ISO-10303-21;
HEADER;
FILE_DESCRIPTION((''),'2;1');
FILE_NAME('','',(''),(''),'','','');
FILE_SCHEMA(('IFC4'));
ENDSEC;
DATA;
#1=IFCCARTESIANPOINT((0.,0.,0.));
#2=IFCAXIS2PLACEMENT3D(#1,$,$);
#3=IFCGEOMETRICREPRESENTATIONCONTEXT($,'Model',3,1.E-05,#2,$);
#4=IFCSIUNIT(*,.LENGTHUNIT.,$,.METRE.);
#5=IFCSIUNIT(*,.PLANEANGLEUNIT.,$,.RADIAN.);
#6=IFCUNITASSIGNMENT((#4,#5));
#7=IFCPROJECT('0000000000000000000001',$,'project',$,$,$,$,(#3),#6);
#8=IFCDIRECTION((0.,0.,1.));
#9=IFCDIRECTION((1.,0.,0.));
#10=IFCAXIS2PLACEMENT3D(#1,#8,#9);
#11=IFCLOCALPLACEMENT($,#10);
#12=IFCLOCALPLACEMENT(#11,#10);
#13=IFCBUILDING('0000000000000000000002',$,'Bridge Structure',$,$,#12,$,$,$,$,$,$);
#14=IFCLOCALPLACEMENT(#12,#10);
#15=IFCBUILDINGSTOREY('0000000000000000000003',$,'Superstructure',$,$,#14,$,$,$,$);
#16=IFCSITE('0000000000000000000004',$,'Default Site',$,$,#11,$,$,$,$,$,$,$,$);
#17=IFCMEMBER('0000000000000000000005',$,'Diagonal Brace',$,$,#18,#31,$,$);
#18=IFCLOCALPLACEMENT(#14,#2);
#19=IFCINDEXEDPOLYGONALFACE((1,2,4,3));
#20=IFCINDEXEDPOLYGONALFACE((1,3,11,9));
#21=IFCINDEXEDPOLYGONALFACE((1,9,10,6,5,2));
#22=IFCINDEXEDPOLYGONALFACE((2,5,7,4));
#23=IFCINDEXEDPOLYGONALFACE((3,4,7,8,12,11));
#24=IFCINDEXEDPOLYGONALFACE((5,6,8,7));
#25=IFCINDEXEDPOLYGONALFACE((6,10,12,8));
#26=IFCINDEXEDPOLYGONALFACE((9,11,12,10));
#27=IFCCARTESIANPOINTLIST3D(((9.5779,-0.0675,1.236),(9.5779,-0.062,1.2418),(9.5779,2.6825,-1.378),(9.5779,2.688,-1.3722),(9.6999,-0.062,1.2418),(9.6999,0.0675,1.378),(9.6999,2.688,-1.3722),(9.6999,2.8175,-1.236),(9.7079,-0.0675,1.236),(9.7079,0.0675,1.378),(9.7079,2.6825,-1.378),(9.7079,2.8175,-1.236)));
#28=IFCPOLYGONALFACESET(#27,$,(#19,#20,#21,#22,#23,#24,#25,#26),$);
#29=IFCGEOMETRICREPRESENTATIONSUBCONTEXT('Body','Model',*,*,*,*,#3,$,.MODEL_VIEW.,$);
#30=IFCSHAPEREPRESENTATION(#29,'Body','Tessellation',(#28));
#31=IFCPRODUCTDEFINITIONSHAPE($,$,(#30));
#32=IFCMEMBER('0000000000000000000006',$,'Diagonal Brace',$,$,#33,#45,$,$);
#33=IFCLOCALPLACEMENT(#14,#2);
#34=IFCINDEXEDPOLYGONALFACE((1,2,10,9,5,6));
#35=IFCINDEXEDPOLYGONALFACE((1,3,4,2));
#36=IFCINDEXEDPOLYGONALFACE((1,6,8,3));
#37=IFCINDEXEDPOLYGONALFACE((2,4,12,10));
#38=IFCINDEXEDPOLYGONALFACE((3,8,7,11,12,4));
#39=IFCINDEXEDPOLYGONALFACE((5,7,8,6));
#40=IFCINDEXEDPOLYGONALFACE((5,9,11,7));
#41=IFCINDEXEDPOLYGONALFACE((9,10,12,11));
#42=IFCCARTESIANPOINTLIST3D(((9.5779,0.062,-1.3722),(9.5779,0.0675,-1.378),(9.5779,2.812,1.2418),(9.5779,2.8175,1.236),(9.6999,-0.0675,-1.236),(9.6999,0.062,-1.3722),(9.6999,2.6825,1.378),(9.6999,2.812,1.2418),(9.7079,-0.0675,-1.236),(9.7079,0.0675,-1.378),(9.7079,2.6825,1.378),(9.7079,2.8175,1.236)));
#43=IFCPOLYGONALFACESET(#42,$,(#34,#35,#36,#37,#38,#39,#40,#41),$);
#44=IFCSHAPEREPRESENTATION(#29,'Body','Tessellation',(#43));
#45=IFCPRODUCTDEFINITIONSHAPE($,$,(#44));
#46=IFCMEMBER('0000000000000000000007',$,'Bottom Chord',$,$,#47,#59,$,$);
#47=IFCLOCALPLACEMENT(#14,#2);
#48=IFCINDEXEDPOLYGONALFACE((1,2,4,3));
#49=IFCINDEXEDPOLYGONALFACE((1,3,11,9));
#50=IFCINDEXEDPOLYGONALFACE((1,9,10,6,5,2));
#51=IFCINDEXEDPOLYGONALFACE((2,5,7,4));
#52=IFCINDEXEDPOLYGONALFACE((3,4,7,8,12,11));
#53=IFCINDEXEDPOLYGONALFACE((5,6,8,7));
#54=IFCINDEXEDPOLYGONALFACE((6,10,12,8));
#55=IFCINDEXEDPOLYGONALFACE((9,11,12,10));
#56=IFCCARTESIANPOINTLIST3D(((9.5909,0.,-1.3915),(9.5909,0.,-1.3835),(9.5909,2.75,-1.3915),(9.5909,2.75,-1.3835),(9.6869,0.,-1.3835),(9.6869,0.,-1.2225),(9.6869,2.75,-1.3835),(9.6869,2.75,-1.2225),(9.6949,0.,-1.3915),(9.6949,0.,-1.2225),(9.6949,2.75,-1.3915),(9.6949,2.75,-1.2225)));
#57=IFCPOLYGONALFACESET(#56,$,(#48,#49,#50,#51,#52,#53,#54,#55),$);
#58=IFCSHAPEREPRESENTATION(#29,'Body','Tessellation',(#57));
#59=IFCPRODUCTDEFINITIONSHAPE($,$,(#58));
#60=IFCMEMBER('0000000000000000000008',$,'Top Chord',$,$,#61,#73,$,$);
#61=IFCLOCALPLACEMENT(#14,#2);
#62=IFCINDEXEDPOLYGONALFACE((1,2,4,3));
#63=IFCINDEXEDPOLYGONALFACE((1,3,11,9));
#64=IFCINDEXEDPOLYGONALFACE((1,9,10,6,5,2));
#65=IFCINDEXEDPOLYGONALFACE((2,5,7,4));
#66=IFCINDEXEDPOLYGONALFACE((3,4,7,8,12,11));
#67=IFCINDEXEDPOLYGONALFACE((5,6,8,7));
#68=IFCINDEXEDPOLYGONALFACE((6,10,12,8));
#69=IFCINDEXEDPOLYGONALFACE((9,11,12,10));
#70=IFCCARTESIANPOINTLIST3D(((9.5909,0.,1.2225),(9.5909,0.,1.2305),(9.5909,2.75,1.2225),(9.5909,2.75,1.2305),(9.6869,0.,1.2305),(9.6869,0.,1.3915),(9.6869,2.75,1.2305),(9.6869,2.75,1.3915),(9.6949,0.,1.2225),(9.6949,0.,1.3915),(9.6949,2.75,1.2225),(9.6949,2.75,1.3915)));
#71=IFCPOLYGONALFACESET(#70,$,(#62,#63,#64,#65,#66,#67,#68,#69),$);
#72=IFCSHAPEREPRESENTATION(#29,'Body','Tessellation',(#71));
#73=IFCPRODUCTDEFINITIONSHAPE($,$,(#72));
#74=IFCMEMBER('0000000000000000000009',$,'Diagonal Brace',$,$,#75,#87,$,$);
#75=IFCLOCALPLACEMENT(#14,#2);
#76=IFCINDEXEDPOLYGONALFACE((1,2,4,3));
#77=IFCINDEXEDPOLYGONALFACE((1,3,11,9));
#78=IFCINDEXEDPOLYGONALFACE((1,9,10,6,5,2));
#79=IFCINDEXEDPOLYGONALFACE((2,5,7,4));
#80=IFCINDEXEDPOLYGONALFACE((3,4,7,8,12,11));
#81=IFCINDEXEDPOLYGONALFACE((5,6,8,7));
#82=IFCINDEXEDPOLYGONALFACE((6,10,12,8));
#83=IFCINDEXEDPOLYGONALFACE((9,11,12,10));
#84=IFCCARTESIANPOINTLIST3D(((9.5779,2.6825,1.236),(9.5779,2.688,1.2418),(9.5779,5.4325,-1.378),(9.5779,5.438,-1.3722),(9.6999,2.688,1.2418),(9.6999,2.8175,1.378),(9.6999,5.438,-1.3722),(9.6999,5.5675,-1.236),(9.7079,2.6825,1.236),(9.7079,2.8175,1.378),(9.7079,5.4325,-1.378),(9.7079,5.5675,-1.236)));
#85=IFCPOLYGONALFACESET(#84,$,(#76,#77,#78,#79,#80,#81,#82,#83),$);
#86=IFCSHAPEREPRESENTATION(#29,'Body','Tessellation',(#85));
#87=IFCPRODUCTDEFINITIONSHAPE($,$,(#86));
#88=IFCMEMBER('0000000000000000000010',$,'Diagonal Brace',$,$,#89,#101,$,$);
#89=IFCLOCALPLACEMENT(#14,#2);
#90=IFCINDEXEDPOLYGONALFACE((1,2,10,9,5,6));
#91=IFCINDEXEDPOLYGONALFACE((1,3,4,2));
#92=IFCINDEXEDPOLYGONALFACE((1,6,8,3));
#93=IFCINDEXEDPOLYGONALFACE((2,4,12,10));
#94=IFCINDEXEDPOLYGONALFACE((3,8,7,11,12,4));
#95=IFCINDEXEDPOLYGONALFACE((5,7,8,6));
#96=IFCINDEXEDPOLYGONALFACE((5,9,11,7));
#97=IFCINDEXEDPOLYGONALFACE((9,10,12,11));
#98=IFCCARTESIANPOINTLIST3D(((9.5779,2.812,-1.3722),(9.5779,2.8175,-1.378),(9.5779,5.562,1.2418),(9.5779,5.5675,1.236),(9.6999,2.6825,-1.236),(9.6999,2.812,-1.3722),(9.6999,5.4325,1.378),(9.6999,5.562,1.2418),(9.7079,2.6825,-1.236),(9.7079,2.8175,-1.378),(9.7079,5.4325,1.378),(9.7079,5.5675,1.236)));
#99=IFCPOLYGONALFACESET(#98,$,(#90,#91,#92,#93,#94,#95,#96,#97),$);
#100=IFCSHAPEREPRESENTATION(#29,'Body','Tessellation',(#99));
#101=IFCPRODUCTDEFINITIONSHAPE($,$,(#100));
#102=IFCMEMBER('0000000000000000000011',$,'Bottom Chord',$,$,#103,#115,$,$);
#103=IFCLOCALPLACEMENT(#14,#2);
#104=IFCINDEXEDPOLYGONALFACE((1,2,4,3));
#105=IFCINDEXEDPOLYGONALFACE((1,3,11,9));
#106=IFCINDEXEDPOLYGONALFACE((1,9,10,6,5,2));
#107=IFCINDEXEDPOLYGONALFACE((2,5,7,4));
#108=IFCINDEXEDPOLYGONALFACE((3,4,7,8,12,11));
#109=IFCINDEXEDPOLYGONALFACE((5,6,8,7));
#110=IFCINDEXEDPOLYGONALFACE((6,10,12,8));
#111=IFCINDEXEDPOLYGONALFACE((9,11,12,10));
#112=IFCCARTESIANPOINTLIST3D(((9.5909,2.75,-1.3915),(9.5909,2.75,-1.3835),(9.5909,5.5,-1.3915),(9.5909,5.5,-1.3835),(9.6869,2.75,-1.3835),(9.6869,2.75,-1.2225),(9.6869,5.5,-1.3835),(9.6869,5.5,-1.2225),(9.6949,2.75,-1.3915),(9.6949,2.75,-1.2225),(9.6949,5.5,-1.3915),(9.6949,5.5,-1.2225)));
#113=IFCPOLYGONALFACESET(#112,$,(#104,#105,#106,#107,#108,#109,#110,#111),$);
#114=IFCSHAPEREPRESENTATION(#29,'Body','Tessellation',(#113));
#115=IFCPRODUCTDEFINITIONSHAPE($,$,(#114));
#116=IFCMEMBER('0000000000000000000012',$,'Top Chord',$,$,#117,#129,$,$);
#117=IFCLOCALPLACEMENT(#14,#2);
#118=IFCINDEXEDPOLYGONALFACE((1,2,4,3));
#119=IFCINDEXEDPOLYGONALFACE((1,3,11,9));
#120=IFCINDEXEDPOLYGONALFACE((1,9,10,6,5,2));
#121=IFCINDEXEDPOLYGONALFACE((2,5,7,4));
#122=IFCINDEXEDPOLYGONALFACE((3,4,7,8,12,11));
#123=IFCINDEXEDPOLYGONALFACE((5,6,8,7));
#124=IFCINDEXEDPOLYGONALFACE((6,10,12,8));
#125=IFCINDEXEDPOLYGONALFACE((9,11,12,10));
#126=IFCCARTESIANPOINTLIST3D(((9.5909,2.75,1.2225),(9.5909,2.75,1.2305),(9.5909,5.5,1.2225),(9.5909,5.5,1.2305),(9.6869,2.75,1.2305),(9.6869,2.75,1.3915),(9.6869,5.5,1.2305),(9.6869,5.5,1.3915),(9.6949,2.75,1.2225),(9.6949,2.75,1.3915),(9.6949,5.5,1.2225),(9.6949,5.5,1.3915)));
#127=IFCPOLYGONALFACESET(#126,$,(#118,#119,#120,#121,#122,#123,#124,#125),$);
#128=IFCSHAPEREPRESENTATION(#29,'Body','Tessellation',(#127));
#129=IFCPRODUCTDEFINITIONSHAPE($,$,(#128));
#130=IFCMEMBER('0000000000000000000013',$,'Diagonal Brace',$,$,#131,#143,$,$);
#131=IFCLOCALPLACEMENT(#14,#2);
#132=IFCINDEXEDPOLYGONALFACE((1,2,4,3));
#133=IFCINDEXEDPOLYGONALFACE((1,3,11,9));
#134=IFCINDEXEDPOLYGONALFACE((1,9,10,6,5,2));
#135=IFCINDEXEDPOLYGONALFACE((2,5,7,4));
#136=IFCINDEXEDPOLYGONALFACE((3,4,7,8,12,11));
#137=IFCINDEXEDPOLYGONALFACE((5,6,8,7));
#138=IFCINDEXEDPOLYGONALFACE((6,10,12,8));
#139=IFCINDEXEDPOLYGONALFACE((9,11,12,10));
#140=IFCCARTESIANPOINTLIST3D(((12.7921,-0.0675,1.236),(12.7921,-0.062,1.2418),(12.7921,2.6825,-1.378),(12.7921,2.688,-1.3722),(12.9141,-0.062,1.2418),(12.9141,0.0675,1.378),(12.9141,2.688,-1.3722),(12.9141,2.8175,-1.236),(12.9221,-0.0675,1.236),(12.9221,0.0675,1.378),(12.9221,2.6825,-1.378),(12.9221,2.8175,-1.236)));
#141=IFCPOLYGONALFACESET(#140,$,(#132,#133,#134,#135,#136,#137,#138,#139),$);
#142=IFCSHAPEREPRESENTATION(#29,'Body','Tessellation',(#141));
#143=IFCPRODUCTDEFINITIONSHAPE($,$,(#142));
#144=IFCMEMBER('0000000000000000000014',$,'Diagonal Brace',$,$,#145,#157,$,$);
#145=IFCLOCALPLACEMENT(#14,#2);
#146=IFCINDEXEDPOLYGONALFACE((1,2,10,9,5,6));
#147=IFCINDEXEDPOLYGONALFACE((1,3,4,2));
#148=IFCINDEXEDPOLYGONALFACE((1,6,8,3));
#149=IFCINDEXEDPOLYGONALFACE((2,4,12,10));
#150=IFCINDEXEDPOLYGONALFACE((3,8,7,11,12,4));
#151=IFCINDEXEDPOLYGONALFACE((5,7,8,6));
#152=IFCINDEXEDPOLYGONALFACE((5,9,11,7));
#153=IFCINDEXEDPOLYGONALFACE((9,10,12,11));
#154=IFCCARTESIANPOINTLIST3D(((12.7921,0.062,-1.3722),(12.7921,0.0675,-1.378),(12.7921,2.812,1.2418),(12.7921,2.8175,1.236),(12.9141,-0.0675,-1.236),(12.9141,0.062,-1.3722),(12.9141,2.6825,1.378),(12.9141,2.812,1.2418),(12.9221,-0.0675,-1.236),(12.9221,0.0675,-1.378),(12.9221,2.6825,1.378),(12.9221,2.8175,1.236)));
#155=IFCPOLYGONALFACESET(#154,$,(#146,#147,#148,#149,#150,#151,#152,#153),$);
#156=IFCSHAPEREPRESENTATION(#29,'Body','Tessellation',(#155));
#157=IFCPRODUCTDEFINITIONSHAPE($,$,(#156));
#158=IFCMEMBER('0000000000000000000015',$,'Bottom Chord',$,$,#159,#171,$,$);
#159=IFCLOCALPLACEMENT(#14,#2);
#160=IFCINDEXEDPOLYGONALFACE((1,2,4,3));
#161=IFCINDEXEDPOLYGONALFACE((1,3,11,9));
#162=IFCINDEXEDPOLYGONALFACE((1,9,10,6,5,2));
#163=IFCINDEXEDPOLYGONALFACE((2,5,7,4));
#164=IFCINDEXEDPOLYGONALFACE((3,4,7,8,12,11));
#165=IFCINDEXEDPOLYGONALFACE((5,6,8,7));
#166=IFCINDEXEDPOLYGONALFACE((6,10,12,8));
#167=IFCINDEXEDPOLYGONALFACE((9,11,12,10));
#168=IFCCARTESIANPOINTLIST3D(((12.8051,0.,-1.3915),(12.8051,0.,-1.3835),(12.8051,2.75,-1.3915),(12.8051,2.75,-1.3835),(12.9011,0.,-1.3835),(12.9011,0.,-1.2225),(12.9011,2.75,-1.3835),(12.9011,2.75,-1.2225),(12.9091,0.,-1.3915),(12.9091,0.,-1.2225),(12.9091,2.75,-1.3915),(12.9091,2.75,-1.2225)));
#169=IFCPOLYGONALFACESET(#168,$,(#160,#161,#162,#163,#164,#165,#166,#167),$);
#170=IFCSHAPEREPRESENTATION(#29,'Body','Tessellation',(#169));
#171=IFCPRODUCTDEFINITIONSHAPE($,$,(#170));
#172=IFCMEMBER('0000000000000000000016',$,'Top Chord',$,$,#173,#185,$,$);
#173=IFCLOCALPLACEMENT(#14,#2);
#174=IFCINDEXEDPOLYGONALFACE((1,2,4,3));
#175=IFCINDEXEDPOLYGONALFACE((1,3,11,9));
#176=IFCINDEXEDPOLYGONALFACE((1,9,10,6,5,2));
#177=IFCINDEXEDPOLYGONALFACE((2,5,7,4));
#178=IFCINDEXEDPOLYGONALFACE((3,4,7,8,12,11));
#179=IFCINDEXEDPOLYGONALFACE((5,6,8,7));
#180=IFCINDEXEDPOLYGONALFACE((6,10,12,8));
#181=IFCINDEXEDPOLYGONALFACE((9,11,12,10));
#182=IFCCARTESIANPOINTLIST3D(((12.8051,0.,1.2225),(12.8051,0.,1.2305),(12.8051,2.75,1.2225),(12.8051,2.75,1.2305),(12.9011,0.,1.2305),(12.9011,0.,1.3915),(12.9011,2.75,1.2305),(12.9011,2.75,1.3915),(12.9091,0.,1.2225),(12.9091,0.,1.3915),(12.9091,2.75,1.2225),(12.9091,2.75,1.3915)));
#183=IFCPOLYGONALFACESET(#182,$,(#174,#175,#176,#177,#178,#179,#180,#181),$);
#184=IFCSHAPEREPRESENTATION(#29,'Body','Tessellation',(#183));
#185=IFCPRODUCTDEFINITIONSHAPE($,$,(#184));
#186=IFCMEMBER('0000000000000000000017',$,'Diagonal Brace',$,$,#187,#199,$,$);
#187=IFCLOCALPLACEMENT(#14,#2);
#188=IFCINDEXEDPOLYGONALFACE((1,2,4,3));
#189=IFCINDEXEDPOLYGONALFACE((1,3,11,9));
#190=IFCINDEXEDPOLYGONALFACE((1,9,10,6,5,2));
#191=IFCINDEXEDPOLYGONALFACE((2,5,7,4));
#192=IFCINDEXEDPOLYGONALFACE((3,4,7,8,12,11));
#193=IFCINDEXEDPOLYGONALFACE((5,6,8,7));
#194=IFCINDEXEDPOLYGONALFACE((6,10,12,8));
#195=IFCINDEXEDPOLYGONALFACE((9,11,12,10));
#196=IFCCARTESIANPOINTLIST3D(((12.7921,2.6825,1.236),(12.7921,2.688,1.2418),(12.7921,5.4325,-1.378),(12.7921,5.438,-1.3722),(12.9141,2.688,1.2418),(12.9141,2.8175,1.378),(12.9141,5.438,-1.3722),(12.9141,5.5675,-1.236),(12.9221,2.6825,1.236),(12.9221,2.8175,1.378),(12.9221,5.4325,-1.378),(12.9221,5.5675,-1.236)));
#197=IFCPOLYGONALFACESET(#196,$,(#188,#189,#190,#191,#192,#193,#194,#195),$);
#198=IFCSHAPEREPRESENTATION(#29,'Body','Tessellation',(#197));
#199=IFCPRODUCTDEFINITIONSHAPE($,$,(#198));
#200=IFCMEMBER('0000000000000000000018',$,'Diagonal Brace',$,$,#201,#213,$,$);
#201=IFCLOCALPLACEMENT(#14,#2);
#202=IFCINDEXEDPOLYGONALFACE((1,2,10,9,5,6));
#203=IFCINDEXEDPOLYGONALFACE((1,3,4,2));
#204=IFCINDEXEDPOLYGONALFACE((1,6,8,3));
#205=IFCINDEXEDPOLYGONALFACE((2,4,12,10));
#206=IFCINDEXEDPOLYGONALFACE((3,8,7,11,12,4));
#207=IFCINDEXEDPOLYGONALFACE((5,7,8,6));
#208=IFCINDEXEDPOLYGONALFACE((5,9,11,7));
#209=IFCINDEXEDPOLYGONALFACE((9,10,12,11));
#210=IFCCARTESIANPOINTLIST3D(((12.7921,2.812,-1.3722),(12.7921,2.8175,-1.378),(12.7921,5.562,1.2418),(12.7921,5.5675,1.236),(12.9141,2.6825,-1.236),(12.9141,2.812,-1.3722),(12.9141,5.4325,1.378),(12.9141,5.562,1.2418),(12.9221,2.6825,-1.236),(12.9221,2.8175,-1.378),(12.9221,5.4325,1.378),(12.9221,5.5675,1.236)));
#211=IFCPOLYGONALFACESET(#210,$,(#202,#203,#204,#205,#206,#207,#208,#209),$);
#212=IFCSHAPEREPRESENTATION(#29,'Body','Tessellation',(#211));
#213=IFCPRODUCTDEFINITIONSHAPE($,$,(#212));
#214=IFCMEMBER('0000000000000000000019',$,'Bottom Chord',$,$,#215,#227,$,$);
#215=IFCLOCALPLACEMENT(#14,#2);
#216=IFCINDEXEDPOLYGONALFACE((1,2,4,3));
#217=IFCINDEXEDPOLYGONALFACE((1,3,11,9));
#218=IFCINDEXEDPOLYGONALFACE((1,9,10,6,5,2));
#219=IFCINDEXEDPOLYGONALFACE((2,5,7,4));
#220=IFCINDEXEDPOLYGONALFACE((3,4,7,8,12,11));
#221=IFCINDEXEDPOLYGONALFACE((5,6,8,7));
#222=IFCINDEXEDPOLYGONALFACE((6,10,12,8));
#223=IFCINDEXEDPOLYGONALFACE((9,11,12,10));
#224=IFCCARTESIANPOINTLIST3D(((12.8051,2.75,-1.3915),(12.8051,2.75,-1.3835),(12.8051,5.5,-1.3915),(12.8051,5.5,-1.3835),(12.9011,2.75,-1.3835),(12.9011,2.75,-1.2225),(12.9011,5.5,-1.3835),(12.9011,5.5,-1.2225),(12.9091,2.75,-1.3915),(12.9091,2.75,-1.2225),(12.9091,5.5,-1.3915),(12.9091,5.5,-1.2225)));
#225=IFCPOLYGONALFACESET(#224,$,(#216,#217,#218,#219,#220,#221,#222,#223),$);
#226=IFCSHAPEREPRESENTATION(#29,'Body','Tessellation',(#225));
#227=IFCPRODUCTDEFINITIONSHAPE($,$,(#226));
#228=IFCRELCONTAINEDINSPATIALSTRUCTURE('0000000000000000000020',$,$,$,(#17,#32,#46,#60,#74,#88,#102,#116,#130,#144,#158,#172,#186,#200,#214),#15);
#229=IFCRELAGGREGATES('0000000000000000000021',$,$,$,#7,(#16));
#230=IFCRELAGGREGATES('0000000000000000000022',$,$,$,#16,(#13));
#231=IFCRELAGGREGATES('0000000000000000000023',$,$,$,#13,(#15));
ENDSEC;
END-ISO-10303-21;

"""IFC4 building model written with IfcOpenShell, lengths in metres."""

from ifc_helpers import new_model, si_unit, frame, origin, origin_with_axes, origin_2d_with_axis, place, context, subcontext, project, spatial, l_section, extrude, element, save


model = new_model("IFC4")

# Units and contexts
model_context = context("Model", 3, precision=1e-05, world=origin())
body_context = subcontext(model_context, "Body", "Model", "MODEL_VIEW")
ifc_project = project(units=[si_unit("LENGTHUNIT", "METRE"), si_unit("PLANEANGLEUNIT", "RADIAN")], contexts=[model_context])

# Site, building, storey
site_placement = place(None, origin_with_axes())
site = spatial("IfcSite", under=ifc_project, at=site_placement, Name="Default Site")
building_placement = place(site_placement, origin_with_axes())
building = spatial("IfcBuilding", under=site, at=building_placement, Name="Bridge Structure")
storey_placement = place(building_placement, origin_with_axes())
storey = spatial("IfcBuildingStorey", under=building, at=storey_placement, Name="Superstructure")

# Members
for number, where, z_axis, x_axis, name in (
    (1, (9.6429, 0.0, 1.307), (0.0, 0.724802, -0.688957), (-1.0, 0.0, 0.0), "Diagonal Brace"),
    (2, (9.6429, 0.0, -1.307), (0.0, 0.724802, 0.688957), (-1.0, 0.0, 0.0), "Diagonal Brace"),
):
    element("IfcMember", number, at=place(storey_placement, frame(where, z_axis=z_axis, x_axis=x_axis)), inside=storey, Name=name, context=body_context, shape_type="SweptSolid", body=[
        extrude(l_section(Depth=0.196, Width=0.13, Thickness=0.008, at=origin_2d_with_axis()), origin_with_axes(), (0.0, 0.0, 1.0), 3.7941),
    ])
for number, where, z_axis, x_axis, name in (
    (3, (9.6429, 0.0, -1.307), (0.0, 1.0, 0.0), (-1.0, 0.0, 0.0), "Bottom Chord"),
    (4, (9.6429, 0.0, 1.307), (0.0, 1.0, 0.0), (-1.0, 0.0, 0.0), "Top Chord"),
):
    element("IfcMember", number, at=place(storey_placement, frame(where, z_axis=z_axis, x_axis=x_axis)), inside=storey, Name=name, context=body_context, shape_type="SweptSolid", body=[
        extrude(l_section(Depth=0.169, Width=0.104, Thickness=0.008, at=origin_2d_with_axis()), origin_with_axes(), (0.0, 0.0, 1.0), 2.75),
    ])
for number, where, z_axis, x_axis, name in (
    (5, (9.6429, 2.75, 1.307), (0.0, 0.724802, -0.688957), (-1.0, 0.0, 0.0), "Diagonal Brace"),
    (6, (9.6429, 2.75, -1.307), (0.0, 0.724802, 0.688957), (-1.0, 0.0, 0.0), "Diagonal Brace"),
):
    element("IfcMember", number, at=place(storey_placement, frame(where, z_axis=z_axis, x_axis=x_axis)), inside=storey, Name=name, context=body_context, shape_type="SweptSolid", body=[
        extrude(l_section(Depth=0.196, Width=0.13, Thickness=0.008, at=origin_2d_with_axis()), origin_with_axes(), (0.0, 0.0, 1.0), 3.7941),
    ])
for number, where, z_axis, x_axis, name in (
    (7, (9.6429, 2.75, -1.307), (0.0, 1.0, 0.0), (-1.0, 0.0, 0.0), "Bottom Chord"),
    (8, (9.6429, 2.75, 1.307), (0.0, 1.0, 0.0), (-1.0, 0.0, 0.0), "Top Chord"),
):
    element("IfcMember", number, at=place(storey_placement, frame(where, z_axis=z_axis, x_axis=x_axis)), inside=storey, Name=name, context=body_context, shape_type="SweptSolid", body=[
        extrude(l_section(Depth=0.169, Width=0.104, Thickness=0.008, at=origin_2d_with_axis()), origin_with_axes(), (0.0, 0.0, 1.0), 2.75),
    ])
for number, where, z_axis, x_axis, name in (
    (9, (12.8571, 0.0, 1.307), (0.0, 0.724802, -0.688957), (-1.0, 0.0, 0.0), "Diagonal Brace"),
    (10, (12.8571, 0.0, -1.307), (0.0, 0.724802, 0.688957), (-1.0, 0.0, 0.0), "Diagonal Brace"),
):
    element("IfcMember", number, at=place(storey_placement, frame(where, z_axis=z_axis, x_axis=x_axis)), inside=storey, Name=name, context=body_context, shape_type="SweptSolid", body=[
        extrude(l_section(Depth=0.196, Width=0.13, Thickness=0.008, at=origin_2d_with_axis()), origin_with_axes(), (0.0, 0.0, 1.0), 3.7941),
    ])
for number, where, z_axis, x_axis, name in (
    (11, (12.8571, 0.0, -1.307), (0.0, 1.0, 0.0), (-1.0, 0.0, 0.0), "Bottom Chord"),
    (12, (12.8571, 0.0, 1.307), (0.0, 1.0, 0.0), (-1.0, 0.0, 0.0), "Top Chord"),
):
    element("IfcMember", number, at=place(storey_placement, frame(where, z_axis=z_axis, x_axis=x_axis)), inside=storey, Name=name, context=body_context, shape_type="SweptSolid", body=[
        extrude(l_section(Depth=0.169, Width=0.104, Thickness=0.008, at=origin_2d_with_axis()), origin_with_axes(), (0.0, 0.0, 1.0), 2.75),
    ])
for number, where, z_axis, x_axis, name in (
    (13, (12.8571, 2.75, 1.307), (0.0, 0.724802, -0.688957), (-1.0, 0.0, 0.0), "Diagonal Brace"),
    (14, (12.8571, 2.75, -1.307), (0.0, 0.724802, 0.688957), (-1.0, 0.0, 0.0), "Diagonal Brace"),
):
    element("IfcMember", number, at=place(storey_placement, frame(where, z_axis=z_axis, x_axis=x_axis)), inside=storey, Name=name, context=body_context, shape_type="SweptSolid", body=[
        extrude(l_section(Depth=0.196, Width=0.13, Thickness=0.008, at=origin_2d_with_axis()), origin_with_axes(), (0.0, 0.0, 1.0), 3.7941),
    ])
for number, where, z_axis, x_axis, name in (
    (15, (12.8571, 2.75, -1.307), (0.0, 1.0, 0.0), (-1.0, 0.0, 0.0), "Bottom Chord"),
):
    element("IfcMember", number, at=place(storey_placement, frame(where, z_axis=z_axis, x_axis=x_axis)), inside=storey, Name=name, context=body_context, shape_type="SweptSolid", body=[
        extrude(l_section(Depth=0.169, Width=0.104, Thickness=0.008, at=origin_2d_with_axis()), origin_with_axes(), (0.0, 0.0, 1.0), 2.75),
    ])

save(model, "model.ifc")
